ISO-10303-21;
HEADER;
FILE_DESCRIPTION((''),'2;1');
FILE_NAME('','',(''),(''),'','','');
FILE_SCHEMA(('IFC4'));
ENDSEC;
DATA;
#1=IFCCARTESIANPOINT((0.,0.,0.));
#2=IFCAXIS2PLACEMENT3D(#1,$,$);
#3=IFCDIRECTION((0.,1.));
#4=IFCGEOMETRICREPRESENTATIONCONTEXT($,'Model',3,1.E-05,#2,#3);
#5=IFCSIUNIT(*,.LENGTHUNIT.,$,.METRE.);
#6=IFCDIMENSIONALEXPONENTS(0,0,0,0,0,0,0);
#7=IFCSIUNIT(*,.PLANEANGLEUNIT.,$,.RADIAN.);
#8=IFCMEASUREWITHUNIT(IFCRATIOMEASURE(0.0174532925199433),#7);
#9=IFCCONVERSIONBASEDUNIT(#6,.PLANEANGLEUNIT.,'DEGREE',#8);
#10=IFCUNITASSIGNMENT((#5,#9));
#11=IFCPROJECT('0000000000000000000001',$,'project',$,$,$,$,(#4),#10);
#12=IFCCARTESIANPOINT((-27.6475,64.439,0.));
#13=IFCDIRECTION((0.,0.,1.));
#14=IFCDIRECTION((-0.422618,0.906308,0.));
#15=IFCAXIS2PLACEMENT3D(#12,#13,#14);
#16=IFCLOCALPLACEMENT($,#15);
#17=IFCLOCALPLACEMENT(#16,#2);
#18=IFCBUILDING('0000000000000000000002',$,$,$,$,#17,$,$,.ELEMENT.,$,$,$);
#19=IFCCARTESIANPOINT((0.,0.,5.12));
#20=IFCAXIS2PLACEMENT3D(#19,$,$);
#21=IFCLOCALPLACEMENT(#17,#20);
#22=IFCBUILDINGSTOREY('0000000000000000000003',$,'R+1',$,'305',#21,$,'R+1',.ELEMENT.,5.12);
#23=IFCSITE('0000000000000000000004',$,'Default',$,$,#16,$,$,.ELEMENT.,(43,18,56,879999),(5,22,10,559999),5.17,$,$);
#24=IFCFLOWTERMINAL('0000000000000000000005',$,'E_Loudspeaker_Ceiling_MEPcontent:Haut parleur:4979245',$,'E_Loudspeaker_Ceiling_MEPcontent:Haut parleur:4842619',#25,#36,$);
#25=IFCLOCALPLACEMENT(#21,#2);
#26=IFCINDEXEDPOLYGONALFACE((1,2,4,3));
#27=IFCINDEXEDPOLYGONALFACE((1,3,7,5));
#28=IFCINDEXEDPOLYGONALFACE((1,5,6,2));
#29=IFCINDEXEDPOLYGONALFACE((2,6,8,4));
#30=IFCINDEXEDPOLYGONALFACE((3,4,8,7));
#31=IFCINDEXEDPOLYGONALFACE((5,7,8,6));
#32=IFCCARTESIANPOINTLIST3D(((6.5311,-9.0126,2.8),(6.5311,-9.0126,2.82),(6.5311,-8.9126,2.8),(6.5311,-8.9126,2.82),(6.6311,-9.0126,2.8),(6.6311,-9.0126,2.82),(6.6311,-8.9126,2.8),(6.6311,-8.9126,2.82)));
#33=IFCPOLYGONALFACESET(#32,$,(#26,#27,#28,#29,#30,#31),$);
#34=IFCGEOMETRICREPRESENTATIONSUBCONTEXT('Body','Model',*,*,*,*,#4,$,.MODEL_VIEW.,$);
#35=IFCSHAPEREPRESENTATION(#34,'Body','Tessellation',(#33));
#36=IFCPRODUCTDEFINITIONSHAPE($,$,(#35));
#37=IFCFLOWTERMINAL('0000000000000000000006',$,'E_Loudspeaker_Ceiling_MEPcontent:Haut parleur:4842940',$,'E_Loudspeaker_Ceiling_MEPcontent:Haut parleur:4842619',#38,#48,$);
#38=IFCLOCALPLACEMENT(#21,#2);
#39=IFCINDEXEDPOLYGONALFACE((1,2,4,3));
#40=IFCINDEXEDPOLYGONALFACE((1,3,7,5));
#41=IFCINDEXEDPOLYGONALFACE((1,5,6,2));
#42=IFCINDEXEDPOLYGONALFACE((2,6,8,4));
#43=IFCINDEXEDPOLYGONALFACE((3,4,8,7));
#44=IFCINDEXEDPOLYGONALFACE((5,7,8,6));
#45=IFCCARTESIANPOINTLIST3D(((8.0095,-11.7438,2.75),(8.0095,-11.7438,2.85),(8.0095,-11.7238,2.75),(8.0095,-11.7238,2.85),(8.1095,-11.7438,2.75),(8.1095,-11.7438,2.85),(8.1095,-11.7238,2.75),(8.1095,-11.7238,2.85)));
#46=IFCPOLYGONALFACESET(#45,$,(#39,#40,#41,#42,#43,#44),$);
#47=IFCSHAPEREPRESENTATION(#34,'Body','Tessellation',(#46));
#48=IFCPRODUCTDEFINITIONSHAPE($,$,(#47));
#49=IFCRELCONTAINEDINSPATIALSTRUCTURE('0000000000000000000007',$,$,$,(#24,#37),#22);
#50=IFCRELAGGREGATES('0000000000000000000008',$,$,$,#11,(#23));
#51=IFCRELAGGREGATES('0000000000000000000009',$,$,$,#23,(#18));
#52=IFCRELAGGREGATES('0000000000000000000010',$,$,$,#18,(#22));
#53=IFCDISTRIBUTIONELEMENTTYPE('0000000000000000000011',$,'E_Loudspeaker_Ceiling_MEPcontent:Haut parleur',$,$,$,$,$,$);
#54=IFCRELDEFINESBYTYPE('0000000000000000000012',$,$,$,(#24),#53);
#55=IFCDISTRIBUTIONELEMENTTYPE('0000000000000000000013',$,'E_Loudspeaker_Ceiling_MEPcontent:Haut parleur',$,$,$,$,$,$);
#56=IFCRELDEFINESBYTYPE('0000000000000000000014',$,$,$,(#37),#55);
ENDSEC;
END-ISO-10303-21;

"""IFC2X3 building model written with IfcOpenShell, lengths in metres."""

from ifc_helpers import new_model, entity, si_unit, converted_unit, direction, frame, frame_2d, origin, origin_2d_with_axis, place, context, subcontext, project, spatial, rectangle, extrude, source, transform, mapped, type_object, type_shapes, element, save


model = new_model("IFC2X3")

# Units and contexts
model_context = context("Model", 3, precision=1e-05, world=origin(), true_north=direction((0.0, 1.0)))
body_context = subcontext(model_context, "Body", "Model", "MODEL_VIEW")
ifc_project = project(units=[si_unit("LENGTHUNIT", "METRE"), converted_unit("PLANEANGLEUNIT", "DEGREE", entity("IfcRatioMeasure", 0.0174532925199433), si_unit("PLANEANGLEUNIT", "RADIAN"), dimensions=[0, 0, 0, 0, 0, 0, 0])], contexts=[model_context])

# Site, building, storey
site_placement = place(None, frame((-27.6475, 64.439, 0.0), z_axis=(0.0, 0.0, 1.0), x_axis=(-0.422618, 0.906308, 0.0)))
site = spatial("IfcSite", under=ifc_project, at=site_placement, Name="Default", CompositionType="ELEMENT", RefLatitude=(43, 18, 56, 879999), RefLongitude=(5, 22, 10, 559999), RefElevation=5.17)
building_placement = place(site_placement, origin())
building = spatial("IfcBuilding", under=site, at=building_placement, CompositionType="ELEMENT")
storey_placement = place(building_placement, frame((0.0, 0.0, 5.12)))
storey = spatial("IfcBuildingStorey", under=building, at=storey_placement, Name="R+1", ObjectType="305", LongName="R+1", CompositionType="ELEMENT", Elevation=5.12)

# Flow terminals
distribution_element_type_1 = type_object("IfcDistributionElementType", Name="E_Loudspeaker_Ceiling_MEPcontent:Haut parleur")
shared_shape_1 = source(origin(), body_context, "Body", "SweptSolid", [
    extrude(rectangle(XDim=0.1, YDim=0.1, at=origin_2d_with_axis()), frame((0.0, 0.0, 0.0), z_axis=(0.0, 0.0, 1.0), x_axis=(0.0, -1.0, 0.0)), (0.0, 0.0, 1.0), 0.02),
])
type_shapes(distribution_element_type_1, [shared_shape_1])
for number, where, z_axis, x_axis, name in (
    (1, (6.5811, -8.9626, 2.8), (0.0, 0.0, 1.0), (-1.0, 0.0, 0.0), "E_Loudspeaker_Ceiling_MEPcontent:Haut parleur:4979245"),
):
    element("IfcFlowTerminal", number, at=place(storey_placement, frame(where, z_axis=z_axis, x_axis=x_axis)), inside=storey, type_object=distribution_element_type_1, Name=name, ObjectType="E_Loudspeaker_Ceiling_MEPcontent:Haut parleur:4842619", context=body_context, shape_type="MappedRepresentation", body=[
        mapped(shared_shape_1, transform((0.0, 0.0, 0.0), scale=1.0)),
    ])
distribution_element_type_2 = type_object("IfcDistributionElementType", Name="E_Loudspeaker_Ceiling_MEPcontent:Haut parleur")
shared_shape_2 = source(origin(), body_context, "Body", "SweptSolid", [
    extrude(rectangle(XDim=0.02, YDim=0.1, at=frame_2d((0.0, 0.0), x_axis=(1.0, 0.0))), frame((0.0, 0.01, -0.05), z_axis=(0.0, 0.0, 1.0), x_axis=(0.0, -1.0, 0.0)), (0.0, 0.0, 1.0), 0.1),
])
type_shapes(distribution_element_type_2, [shared_shape_2])
flow_terminal_1_placement = place(storey_placement, frame((8.0595, -11.7238, 2.8), z_axis=(0.0, 0.0, 1.0), x_axis=(-1.0, 0.0, 0.0)))
element("IfcFlowTerminal", 2, at=flow_terminal_1_placement, inside=storey, type_object=distribution_element_type_2, Name="E_Loudspeaker_Ceiling_MEPcontent:Haut parleur:4842940", ObjectType="E_Loudspeaker_Ceiling_MEPcontent:Haut parleur:4842619", context=body_context, shape_type="MappedRepresentation", body=[
    mapped(shared_shape_2, transform((0.0, 0.0, 0.0), scale=1.0)),
])

save(model, "model.ifc")
